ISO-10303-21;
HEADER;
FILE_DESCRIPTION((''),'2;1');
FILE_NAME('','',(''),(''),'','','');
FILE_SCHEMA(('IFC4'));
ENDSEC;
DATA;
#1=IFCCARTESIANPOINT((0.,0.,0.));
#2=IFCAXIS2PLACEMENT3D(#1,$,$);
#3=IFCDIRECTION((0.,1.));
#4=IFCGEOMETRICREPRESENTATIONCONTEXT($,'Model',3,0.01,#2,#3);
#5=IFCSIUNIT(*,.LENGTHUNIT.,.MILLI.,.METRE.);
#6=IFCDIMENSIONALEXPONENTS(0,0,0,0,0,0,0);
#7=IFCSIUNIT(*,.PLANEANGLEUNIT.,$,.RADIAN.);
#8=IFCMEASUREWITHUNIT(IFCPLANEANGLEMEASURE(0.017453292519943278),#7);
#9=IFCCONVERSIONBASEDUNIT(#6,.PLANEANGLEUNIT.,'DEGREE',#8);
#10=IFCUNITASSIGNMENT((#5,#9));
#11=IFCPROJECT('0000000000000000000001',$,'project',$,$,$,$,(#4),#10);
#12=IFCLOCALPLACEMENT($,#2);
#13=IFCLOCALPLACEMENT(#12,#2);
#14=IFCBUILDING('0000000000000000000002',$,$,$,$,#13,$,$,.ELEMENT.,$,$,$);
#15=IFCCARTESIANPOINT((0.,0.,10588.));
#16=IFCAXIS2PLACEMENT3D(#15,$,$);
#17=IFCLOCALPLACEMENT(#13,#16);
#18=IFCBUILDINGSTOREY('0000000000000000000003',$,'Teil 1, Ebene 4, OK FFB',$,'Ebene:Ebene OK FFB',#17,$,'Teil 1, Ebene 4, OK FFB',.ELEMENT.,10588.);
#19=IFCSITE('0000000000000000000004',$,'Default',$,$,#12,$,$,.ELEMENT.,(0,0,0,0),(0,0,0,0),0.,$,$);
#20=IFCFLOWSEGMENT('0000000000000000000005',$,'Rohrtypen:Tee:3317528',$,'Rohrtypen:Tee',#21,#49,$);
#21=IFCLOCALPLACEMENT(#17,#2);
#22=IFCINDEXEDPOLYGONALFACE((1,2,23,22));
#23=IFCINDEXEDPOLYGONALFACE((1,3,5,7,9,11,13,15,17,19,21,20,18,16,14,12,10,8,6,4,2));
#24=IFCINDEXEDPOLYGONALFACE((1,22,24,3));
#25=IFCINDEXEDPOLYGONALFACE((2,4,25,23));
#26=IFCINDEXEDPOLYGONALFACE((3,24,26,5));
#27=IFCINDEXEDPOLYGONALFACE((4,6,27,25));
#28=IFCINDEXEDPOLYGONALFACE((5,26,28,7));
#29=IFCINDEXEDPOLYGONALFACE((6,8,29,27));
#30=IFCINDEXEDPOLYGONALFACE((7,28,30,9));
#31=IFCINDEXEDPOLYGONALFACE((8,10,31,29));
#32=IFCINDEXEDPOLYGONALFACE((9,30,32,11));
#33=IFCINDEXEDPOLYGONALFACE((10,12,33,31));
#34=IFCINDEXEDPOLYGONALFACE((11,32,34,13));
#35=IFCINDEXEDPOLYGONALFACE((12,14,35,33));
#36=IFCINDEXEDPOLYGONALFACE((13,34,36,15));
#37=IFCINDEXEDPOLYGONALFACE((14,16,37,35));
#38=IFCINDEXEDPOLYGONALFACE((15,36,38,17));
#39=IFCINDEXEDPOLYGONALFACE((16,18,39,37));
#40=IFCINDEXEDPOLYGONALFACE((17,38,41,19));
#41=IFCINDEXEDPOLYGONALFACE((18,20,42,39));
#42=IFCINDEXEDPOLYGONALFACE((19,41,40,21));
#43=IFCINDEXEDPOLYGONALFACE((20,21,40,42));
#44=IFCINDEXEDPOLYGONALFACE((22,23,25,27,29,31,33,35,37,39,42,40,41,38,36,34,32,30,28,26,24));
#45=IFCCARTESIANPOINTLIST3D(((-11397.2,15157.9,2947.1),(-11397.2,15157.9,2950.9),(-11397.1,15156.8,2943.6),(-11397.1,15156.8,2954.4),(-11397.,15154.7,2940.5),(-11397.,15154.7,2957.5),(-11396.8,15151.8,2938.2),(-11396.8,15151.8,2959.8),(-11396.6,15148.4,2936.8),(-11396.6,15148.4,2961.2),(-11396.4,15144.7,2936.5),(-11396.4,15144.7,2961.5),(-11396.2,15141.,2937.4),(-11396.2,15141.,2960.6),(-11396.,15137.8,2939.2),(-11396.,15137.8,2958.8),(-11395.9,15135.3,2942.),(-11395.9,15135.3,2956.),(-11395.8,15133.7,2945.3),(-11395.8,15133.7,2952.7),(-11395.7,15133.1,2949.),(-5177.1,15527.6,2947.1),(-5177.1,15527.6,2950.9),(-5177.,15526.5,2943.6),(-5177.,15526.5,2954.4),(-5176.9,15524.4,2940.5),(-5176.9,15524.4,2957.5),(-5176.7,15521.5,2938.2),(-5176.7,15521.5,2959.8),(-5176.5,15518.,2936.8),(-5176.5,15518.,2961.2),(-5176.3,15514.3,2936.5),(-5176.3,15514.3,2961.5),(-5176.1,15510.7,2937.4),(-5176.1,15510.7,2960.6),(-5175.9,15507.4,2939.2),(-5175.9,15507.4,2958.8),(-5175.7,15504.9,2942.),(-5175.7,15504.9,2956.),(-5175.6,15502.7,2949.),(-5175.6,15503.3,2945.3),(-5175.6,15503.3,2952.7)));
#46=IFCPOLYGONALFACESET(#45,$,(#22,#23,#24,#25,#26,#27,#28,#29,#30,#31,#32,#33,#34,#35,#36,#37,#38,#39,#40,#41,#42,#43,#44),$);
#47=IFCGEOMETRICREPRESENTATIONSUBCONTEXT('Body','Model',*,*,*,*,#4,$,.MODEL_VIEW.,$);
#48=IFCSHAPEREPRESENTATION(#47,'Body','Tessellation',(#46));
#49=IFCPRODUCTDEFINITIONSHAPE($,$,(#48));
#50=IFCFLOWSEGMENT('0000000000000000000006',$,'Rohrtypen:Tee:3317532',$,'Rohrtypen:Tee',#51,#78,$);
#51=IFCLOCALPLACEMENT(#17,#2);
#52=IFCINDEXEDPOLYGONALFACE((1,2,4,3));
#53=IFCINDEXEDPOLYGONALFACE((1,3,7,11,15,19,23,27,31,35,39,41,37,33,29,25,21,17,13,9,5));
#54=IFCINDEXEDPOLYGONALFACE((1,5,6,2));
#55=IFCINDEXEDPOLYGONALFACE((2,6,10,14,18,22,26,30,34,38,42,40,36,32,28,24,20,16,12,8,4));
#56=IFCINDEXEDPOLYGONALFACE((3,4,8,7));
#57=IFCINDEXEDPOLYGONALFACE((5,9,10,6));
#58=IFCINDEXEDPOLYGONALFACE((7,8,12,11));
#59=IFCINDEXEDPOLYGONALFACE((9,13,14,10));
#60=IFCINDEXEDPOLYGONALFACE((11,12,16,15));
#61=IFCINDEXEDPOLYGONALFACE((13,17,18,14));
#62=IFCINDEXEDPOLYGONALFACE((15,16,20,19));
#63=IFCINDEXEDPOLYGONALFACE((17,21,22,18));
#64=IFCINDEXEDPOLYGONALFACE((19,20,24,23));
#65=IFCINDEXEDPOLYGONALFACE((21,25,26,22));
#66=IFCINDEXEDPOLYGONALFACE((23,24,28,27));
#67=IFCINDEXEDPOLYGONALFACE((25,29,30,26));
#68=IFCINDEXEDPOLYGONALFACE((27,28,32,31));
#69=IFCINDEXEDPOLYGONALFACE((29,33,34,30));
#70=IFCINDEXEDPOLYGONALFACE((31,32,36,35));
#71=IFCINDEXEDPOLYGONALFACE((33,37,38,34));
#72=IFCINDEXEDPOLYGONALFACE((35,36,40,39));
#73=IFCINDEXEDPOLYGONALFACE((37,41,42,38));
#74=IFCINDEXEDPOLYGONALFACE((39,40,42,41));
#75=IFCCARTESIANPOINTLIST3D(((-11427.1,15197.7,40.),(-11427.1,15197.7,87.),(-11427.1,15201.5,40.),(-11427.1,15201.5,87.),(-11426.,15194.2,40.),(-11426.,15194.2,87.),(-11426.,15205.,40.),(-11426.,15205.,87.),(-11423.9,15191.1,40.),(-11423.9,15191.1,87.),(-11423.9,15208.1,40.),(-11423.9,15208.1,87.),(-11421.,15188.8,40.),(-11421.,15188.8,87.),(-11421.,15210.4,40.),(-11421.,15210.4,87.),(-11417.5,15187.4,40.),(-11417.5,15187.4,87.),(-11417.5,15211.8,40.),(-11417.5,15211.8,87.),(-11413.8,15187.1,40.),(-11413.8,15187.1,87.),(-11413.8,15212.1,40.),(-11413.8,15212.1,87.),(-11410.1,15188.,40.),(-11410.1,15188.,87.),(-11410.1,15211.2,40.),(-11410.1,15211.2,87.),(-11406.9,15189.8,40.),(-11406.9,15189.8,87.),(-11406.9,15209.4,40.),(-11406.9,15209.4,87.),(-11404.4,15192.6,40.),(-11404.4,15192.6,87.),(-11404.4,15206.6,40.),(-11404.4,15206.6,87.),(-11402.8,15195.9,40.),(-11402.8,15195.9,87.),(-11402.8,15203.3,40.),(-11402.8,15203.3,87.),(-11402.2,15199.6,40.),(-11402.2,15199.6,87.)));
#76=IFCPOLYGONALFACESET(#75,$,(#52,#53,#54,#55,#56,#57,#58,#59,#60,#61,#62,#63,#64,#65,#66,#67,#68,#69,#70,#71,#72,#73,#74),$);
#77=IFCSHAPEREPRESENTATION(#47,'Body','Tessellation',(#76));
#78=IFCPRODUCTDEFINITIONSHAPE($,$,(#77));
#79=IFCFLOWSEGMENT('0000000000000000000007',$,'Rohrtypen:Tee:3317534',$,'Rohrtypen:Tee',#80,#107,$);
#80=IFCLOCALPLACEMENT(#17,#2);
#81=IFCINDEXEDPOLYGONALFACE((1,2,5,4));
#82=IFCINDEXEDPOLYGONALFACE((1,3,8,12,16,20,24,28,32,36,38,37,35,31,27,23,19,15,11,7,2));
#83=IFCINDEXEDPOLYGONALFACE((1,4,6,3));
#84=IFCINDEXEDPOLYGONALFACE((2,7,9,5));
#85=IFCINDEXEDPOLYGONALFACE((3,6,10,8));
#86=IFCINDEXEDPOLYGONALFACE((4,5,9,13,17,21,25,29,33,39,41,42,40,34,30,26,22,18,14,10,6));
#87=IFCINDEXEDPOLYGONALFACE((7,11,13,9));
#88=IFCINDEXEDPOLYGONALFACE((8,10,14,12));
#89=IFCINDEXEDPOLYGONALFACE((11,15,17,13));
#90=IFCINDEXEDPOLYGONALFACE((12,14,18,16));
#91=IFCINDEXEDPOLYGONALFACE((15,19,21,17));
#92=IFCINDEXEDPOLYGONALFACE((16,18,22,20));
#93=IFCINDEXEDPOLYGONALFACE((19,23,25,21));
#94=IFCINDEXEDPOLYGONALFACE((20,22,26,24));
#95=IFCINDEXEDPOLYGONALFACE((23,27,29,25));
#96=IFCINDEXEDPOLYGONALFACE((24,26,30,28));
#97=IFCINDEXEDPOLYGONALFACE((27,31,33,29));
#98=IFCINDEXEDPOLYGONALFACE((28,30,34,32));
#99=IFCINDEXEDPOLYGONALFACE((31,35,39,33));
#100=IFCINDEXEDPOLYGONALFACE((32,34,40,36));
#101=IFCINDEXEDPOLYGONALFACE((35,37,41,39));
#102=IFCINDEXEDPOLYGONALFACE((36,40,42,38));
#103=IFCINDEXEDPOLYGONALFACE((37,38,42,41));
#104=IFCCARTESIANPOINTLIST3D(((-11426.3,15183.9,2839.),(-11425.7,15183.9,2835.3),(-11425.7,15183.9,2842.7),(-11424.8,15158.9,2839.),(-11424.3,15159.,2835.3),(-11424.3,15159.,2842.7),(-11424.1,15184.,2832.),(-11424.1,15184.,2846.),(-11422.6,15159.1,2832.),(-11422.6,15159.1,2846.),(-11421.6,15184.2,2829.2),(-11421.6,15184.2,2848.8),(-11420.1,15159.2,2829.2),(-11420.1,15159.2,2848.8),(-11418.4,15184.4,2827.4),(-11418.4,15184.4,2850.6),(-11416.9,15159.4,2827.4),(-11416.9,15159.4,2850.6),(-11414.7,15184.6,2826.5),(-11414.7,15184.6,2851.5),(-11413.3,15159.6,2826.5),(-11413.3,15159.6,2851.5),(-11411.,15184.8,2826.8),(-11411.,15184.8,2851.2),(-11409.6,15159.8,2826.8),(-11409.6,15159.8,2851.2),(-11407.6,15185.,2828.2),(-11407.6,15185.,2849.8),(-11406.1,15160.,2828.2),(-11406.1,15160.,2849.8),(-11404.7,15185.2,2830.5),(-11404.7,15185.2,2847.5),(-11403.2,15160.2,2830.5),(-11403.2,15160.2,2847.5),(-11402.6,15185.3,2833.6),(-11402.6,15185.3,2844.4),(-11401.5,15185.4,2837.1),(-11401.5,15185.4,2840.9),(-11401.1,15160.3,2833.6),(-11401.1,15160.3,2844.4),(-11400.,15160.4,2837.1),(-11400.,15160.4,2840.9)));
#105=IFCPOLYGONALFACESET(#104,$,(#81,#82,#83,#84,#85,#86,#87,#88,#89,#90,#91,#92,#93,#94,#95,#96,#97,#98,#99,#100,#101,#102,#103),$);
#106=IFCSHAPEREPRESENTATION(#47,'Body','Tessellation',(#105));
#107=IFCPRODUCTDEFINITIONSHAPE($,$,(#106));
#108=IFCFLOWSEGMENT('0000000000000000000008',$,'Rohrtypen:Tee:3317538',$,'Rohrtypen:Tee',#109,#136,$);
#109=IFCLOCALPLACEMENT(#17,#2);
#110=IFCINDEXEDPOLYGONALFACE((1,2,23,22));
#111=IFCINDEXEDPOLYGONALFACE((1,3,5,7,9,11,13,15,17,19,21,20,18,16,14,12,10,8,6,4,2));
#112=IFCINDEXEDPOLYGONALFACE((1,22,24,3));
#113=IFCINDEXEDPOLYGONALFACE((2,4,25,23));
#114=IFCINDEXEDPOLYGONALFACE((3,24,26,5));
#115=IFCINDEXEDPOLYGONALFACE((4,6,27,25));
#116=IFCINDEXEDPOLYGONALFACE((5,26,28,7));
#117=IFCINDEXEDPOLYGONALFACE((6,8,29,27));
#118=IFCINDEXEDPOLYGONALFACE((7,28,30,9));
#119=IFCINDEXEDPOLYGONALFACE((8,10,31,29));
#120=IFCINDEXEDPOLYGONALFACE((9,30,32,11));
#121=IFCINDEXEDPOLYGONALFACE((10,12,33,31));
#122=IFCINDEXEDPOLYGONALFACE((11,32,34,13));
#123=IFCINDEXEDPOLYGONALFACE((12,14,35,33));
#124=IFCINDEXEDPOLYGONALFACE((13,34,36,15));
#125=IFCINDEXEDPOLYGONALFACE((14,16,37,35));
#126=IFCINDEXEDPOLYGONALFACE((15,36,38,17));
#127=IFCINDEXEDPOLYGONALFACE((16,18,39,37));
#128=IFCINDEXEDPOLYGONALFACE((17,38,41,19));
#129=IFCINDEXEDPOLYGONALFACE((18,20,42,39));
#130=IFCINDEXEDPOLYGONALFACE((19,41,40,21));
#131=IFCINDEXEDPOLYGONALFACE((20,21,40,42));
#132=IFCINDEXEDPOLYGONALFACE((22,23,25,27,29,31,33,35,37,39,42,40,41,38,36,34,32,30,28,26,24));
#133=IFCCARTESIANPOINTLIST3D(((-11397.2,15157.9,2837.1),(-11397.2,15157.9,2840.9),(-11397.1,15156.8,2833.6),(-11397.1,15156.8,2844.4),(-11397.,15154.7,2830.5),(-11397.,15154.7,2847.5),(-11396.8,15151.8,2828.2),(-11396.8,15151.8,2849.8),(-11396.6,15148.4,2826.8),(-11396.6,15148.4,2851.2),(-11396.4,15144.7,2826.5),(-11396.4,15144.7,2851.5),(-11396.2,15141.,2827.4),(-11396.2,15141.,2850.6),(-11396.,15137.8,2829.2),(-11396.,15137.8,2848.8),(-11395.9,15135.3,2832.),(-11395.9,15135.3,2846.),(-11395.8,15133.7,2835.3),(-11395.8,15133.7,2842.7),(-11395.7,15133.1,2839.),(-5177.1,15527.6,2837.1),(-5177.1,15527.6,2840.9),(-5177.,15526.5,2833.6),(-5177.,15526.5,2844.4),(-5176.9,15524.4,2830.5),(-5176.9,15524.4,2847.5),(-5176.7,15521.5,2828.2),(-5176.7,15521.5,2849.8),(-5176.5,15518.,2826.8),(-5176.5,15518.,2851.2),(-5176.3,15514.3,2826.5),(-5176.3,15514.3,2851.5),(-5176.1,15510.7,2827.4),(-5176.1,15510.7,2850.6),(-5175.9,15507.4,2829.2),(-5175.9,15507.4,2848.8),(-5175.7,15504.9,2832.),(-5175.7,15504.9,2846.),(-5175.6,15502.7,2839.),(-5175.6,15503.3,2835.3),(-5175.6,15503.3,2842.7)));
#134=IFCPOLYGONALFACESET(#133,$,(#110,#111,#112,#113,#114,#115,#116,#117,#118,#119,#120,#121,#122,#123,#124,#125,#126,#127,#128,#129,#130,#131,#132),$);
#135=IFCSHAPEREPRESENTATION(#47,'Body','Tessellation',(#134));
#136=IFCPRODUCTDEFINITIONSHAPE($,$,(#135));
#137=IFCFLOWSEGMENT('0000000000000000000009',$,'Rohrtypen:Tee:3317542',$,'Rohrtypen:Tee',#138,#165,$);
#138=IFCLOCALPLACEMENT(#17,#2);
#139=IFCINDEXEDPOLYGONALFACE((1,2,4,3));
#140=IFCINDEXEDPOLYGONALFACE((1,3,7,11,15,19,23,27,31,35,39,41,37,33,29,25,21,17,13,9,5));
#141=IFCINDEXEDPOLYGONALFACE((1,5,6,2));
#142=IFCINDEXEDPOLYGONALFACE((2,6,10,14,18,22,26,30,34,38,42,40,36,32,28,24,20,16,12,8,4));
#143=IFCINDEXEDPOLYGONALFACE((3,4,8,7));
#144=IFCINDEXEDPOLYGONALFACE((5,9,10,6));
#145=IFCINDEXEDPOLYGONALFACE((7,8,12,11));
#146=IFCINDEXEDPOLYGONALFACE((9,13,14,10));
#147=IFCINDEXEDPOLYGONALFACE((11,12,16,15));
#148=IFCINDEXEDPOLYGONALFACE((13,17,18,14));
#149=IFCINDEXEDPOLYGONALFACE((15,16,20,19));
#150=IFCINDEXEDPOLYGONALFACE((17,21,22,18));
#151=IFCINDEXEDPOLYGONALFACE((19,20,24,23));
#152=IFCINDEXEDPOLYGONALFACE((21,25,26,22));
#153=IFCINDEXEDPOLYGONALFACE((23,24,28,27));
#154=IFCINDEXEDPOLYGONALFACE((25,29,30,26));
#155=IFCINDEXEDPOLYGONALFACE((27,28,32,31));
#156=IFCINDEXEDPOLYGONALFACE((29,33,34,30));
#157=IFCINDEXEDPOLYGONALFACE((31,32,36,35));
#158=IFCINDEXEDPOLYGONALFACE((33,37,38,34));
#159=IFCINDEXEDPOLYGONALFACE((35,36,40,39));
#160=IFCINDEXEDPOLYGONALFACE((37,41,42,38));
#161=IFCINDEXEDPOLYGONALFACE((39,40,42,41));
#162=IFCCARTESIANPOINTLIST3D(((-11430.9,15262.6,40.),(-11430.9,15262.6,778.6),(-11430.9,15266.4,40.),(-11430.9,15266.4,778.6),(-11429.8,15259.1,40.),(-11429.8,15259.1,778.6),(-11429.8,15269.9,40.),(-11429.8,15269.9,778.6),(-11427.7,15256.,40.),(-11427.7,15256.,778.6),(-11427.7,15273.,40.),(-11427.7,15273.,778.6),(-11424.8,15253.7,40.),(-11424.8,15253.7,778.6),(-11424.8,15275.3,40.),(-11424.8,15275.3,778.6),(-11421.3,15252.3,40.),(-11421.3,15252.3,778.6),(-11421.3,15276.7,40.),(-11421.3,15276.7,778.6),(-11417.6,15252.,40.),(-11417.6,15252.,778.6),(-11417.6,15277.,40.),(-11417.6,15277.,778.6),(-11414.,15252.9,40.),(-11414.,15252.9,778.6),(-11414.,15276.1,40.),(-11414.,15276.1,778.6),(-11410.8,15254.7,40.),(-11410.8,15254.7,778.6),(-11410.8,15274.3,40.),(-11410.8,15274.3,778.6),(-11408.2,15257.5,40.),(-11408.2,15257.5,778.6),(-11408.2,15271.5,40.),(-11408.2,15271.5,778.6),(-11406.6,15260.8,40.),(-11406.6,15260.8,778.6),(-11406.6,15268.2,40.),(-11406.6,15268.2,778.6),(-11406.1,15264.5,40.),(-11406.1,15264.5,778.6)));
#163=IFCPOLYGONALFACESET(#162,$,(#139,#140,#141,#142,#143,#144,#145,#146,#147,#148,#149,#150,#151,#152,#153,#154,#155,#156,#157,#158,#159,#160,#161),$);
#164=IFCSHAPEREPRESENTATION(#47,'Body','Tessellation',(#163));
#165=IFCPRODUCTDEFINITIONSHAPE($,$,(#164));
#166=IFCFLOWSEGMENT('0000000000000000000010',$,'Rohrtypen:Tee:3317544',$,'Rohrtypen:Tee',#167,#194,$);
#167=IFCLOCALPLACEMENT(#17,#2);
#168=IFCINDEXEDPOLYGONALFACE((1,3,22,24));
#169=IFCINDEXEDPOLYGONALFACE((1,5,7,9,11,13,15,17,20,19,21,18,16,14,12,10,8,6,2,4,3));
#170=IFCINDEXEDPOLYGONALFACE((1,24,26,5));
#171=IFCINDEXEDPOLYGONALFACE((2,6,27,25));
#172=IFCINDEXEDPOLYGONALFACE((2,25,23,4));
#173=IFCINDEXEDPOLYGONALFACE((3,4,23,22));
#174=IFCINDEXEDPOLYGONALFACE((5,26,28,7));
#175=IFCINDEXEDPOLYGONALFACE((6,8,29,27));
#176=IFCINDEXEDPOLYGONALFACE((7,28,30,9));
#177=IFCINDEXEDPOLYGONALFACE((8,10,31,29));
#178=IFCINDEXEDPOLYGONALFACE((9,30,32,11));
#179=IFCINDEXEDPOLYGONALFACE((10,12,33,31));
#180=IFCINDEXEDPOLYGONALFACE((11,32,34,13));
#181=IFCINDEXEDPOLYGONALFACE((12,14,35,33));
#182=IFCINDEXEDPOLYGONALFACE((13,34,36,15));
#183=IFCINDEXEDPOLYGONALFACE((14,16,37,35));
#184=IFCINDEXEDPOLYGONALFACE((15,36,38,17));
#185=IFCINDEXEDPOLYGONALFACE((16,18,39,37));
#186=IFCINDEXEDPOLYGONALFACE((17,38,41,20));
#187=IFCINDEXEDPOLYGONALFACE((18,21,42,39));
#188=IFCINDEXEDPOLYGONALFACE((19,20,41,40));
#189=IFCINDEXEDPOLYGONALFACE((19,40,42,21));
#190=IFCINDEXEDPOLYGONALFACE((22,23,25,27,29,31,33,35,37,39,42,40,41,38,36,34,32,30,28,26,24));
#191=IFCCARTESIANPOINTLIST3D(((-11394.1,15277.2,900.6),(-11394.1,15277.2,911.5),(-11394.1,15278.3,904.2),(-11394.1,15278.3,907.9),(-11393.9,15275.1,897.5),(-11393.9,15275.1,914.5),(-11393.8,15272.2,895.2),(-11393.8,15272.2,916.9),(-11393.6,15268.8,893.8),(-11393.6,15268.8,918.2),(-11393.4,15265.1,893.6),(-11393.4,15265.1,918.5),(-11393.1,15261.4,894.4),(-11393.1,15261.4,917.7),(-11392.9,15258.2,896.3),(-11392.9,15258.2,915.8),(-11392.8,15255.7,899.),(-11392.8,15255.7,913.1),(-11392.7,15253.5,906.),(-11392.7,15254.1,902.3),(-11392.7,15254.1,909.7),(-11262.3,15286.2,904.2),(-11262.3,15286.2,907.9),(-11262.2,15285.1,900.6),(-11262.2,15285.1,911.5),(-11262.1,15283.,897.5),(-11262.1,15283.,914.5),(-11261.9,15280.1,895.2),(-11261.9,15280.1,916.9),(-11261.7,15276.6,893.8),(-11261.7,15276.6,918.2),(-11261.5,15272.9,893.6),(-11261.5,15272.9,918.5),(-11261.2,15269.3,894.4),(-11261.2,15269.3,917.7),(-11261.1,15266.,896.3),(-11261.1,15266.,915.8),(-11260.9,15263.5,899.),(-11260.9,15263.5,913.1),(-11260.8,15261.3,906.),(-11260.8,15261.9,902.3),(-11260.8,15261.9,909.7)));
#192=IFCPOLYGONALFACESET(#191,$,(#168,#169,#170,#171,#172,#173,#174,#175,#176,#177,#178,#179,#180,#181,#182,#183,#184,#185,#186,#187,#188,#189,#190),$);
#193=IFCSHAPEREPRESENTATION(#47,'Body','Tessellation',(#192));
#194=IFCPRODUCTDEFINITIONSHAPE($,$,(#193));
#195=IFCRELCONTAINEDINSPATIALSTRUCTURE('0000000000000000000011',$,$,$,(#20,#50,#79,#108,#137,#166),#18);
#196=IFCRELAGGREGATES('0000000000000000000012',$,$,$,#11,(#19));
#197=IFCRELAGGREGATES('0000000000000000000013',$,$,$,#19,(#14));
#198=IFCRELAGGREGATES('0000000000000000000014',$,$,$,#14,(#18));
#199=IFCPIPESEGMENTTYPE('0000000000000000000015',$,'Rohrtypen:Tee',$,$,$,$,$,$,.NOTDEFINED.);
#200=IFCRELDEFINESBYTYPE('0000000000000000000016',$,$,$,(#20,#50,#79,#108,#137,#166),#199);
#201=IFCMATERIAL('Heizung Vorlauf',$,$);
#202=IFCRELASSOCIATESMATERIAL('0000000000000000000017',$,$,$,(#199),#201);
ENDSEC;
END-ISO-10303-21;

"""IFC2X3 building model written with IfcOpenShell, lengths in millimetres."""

from ifc_helpers import new_model, entity, si_unit, converted_unit, direction, frame, frame_2d, origin, origin_2d_with_axis, place, context, subcontext, project, spatial, circle, extrude, material, type_object, element, save


model = new_model("IFC2X3")

# Units and contexts
model_context = context("Model", 3, precision=0.01, world=origin(), true_north=direction((0.0, 1.0)))
body_context = subcontext(model_context, "Body", "Model", "MODEL_VIEW")
ifc_project = project(units=[si_unit("LENGTHUNIT", "METRE", prefix="MILLI"), converted_unit("PLANEANGLEUNIT", "DEGREE", entity("IfcPlaneAngleMeasure", 0.017453292519943278), si_unit("PLANEANGLEUNIT", "RADIAN"), dimensions=[0, 0, 0, 0, 0, 0, 0])], contexts=[model_context])

# Site, building, storey
site_placement = place(None, origin())
site = spatial("IfcSite", under=ifc_project, at=site_placement, Name="Default", CompositionType="ELEMENT", RefLatitude=(0, 0, 0, 0), RefLongitude=(0, 0, 0, 0), RefElevation=0.0)
building_placement = place(site_placement, origin())
building = spatial("IfcBuilding", under=site, at=building_placement, CompositionType="ELEMENT")
storey_placement = place(building_placement, frame((0.0, 0.0, 10588.0)))
storey = spatial("IfcBuildingStorey", under=building, at=storey_placement, Name="Teil 1, Ebene 4, OK FFB", ObjectType="Ebene:Ebene OK FFB", LongName="Teil 1, Ebene 4, OK FFB", CompositionType="ELEMENT", Elevation=10588.0)

# Flow segments
ifc_material = material(Name="Heizung Vorlauf")
pipe_segment_type = type_object("IfcPipeSegmentType", Name="Rohrtypen:Tee", PredefinedType="NOTDEFINED", material=ifc_material)
flow_segment_1_placement = place(storey_placement, origin())
element("IfcFlowSegment", 1, at=flow_segment_1_placement, inside=storey, type_object=pipe_segment_type, Name="Rohrtypen:Tee:3317528", ObjectType="Rohrtypen:Tee", context=body_context, shape_type="SweptSolid", body=[
    extrude(circle(Radius=12.5, at=frame_2d((0.0, 0.0), x_axis=(1.0, 0.0))), frame((-11396.5, 15145.6, 2949.0), z_axis=(0.998239, 0.059319, 0.0), x_axis=(0.059319, -0.998239, 0.0)), (0.0, 0.0, 1.0), 6231.1),
])
flow_segment_2_placement = place(storey_placement, origin())
element("IfcFlowSegment", 2, at=flow_segment_2_placement, inside=storey, type_object=pipe_segment_type, Name="Rohrtypen:Tee:3317532", ObjectType="Rohrtypen:Tee", context=body_context, shape_type="SweptSolid", body=[
    extrude(circle(Radius=12.5, at=frame_2d((0.0, 0.0), x_axis=(1.0, 0.0))), frame((-11414.7, 15199.6, 40.0)), (0.0, 0.0, 1.0), 47.0),
])
flow_segment_3_placement = place(storey_placement, origin())
element("IfcFlowSegment", 3, at=flow_segment_3_placement, inside=storey, type_object=pipe_segment_type, Name="Rohrtypen:Tee:3317534", ObjectType="Rohrtypen:Tee", context=body_context, shape_type="SweptSolid", body=[
    extrude(circle(Radius=12.5, at=frame_2d((0.0, 0.0), x_axis=(1.0, 0.0))), frame((-11412.3, 15159.7, 2839.0), z_axis=(-0.059319, 0.998239, 0.0), x_axis=(-0.998239, -0.059319, 0.0)), (0.0, 0.0, 1.0), 25.0),
])
flow_segment_4_placement = place(storey_placement, origin())
element("IfcFlowSegment", 4, at=flow_segment_4_placement, inside=storey, type_object=pipe_segment_type, Name="Rohrtypen:Tee:3317538", ObjectType="Rohrtypen:Tee", context=body_context, shape_type="SweptSolid", body=[
    extrude(circle(Radius=12.5, at=origin_2d_with_axis()), frame((-11396.5, 15145.6, 2839.0), z_axis=(0.998239, 0.059319, 0.0), x_axis=(0.059319, -0.998239, 0.0)), (0.0, 0.0, 1.0), 6231.1),
])
flow_segment_5_placement = place(storey_placement, origin())
element("IfcFlowSegment", 5, at=flow_segment_5_placement, inside=storey, type_object=pipe_segment_type, Name="Rohrtypen:Tee:3317542", ObjectType="Rohrtypen:Tee", context=body_context, shape_type="SweptSolid", body=[
    extrude(circle(Radius=12.5, at=origin_2d_with_axis()), frame((-11418.6, 15264.5, 40.0)), (0.0, 0.0, 1.0), 738.6),
])
flow_segment_6_placement = place(storey_placement, origin())
element("IfcFlowSegment", 6, at=flow_segment_6_placement, inside=storey, type_object=pipe_segment_type, Name="Rohrtypen:Tee:3317544", ObjectType="Rohrtypen:Tee", context=body_context, shape_type="SweptSolid", body=[
    extrude(circle(Radius=12.5, at=origin_2d_with_axis()), frame((-11393.4, 15266.0, 906.0), z_axis=(0.998239, 0.059319, 0.0), x_axis=(0.059319, -0.998239, 0.0)), (0.0, 0.0, 1.0), 132.1),
])

save(model, "model.ifc")
